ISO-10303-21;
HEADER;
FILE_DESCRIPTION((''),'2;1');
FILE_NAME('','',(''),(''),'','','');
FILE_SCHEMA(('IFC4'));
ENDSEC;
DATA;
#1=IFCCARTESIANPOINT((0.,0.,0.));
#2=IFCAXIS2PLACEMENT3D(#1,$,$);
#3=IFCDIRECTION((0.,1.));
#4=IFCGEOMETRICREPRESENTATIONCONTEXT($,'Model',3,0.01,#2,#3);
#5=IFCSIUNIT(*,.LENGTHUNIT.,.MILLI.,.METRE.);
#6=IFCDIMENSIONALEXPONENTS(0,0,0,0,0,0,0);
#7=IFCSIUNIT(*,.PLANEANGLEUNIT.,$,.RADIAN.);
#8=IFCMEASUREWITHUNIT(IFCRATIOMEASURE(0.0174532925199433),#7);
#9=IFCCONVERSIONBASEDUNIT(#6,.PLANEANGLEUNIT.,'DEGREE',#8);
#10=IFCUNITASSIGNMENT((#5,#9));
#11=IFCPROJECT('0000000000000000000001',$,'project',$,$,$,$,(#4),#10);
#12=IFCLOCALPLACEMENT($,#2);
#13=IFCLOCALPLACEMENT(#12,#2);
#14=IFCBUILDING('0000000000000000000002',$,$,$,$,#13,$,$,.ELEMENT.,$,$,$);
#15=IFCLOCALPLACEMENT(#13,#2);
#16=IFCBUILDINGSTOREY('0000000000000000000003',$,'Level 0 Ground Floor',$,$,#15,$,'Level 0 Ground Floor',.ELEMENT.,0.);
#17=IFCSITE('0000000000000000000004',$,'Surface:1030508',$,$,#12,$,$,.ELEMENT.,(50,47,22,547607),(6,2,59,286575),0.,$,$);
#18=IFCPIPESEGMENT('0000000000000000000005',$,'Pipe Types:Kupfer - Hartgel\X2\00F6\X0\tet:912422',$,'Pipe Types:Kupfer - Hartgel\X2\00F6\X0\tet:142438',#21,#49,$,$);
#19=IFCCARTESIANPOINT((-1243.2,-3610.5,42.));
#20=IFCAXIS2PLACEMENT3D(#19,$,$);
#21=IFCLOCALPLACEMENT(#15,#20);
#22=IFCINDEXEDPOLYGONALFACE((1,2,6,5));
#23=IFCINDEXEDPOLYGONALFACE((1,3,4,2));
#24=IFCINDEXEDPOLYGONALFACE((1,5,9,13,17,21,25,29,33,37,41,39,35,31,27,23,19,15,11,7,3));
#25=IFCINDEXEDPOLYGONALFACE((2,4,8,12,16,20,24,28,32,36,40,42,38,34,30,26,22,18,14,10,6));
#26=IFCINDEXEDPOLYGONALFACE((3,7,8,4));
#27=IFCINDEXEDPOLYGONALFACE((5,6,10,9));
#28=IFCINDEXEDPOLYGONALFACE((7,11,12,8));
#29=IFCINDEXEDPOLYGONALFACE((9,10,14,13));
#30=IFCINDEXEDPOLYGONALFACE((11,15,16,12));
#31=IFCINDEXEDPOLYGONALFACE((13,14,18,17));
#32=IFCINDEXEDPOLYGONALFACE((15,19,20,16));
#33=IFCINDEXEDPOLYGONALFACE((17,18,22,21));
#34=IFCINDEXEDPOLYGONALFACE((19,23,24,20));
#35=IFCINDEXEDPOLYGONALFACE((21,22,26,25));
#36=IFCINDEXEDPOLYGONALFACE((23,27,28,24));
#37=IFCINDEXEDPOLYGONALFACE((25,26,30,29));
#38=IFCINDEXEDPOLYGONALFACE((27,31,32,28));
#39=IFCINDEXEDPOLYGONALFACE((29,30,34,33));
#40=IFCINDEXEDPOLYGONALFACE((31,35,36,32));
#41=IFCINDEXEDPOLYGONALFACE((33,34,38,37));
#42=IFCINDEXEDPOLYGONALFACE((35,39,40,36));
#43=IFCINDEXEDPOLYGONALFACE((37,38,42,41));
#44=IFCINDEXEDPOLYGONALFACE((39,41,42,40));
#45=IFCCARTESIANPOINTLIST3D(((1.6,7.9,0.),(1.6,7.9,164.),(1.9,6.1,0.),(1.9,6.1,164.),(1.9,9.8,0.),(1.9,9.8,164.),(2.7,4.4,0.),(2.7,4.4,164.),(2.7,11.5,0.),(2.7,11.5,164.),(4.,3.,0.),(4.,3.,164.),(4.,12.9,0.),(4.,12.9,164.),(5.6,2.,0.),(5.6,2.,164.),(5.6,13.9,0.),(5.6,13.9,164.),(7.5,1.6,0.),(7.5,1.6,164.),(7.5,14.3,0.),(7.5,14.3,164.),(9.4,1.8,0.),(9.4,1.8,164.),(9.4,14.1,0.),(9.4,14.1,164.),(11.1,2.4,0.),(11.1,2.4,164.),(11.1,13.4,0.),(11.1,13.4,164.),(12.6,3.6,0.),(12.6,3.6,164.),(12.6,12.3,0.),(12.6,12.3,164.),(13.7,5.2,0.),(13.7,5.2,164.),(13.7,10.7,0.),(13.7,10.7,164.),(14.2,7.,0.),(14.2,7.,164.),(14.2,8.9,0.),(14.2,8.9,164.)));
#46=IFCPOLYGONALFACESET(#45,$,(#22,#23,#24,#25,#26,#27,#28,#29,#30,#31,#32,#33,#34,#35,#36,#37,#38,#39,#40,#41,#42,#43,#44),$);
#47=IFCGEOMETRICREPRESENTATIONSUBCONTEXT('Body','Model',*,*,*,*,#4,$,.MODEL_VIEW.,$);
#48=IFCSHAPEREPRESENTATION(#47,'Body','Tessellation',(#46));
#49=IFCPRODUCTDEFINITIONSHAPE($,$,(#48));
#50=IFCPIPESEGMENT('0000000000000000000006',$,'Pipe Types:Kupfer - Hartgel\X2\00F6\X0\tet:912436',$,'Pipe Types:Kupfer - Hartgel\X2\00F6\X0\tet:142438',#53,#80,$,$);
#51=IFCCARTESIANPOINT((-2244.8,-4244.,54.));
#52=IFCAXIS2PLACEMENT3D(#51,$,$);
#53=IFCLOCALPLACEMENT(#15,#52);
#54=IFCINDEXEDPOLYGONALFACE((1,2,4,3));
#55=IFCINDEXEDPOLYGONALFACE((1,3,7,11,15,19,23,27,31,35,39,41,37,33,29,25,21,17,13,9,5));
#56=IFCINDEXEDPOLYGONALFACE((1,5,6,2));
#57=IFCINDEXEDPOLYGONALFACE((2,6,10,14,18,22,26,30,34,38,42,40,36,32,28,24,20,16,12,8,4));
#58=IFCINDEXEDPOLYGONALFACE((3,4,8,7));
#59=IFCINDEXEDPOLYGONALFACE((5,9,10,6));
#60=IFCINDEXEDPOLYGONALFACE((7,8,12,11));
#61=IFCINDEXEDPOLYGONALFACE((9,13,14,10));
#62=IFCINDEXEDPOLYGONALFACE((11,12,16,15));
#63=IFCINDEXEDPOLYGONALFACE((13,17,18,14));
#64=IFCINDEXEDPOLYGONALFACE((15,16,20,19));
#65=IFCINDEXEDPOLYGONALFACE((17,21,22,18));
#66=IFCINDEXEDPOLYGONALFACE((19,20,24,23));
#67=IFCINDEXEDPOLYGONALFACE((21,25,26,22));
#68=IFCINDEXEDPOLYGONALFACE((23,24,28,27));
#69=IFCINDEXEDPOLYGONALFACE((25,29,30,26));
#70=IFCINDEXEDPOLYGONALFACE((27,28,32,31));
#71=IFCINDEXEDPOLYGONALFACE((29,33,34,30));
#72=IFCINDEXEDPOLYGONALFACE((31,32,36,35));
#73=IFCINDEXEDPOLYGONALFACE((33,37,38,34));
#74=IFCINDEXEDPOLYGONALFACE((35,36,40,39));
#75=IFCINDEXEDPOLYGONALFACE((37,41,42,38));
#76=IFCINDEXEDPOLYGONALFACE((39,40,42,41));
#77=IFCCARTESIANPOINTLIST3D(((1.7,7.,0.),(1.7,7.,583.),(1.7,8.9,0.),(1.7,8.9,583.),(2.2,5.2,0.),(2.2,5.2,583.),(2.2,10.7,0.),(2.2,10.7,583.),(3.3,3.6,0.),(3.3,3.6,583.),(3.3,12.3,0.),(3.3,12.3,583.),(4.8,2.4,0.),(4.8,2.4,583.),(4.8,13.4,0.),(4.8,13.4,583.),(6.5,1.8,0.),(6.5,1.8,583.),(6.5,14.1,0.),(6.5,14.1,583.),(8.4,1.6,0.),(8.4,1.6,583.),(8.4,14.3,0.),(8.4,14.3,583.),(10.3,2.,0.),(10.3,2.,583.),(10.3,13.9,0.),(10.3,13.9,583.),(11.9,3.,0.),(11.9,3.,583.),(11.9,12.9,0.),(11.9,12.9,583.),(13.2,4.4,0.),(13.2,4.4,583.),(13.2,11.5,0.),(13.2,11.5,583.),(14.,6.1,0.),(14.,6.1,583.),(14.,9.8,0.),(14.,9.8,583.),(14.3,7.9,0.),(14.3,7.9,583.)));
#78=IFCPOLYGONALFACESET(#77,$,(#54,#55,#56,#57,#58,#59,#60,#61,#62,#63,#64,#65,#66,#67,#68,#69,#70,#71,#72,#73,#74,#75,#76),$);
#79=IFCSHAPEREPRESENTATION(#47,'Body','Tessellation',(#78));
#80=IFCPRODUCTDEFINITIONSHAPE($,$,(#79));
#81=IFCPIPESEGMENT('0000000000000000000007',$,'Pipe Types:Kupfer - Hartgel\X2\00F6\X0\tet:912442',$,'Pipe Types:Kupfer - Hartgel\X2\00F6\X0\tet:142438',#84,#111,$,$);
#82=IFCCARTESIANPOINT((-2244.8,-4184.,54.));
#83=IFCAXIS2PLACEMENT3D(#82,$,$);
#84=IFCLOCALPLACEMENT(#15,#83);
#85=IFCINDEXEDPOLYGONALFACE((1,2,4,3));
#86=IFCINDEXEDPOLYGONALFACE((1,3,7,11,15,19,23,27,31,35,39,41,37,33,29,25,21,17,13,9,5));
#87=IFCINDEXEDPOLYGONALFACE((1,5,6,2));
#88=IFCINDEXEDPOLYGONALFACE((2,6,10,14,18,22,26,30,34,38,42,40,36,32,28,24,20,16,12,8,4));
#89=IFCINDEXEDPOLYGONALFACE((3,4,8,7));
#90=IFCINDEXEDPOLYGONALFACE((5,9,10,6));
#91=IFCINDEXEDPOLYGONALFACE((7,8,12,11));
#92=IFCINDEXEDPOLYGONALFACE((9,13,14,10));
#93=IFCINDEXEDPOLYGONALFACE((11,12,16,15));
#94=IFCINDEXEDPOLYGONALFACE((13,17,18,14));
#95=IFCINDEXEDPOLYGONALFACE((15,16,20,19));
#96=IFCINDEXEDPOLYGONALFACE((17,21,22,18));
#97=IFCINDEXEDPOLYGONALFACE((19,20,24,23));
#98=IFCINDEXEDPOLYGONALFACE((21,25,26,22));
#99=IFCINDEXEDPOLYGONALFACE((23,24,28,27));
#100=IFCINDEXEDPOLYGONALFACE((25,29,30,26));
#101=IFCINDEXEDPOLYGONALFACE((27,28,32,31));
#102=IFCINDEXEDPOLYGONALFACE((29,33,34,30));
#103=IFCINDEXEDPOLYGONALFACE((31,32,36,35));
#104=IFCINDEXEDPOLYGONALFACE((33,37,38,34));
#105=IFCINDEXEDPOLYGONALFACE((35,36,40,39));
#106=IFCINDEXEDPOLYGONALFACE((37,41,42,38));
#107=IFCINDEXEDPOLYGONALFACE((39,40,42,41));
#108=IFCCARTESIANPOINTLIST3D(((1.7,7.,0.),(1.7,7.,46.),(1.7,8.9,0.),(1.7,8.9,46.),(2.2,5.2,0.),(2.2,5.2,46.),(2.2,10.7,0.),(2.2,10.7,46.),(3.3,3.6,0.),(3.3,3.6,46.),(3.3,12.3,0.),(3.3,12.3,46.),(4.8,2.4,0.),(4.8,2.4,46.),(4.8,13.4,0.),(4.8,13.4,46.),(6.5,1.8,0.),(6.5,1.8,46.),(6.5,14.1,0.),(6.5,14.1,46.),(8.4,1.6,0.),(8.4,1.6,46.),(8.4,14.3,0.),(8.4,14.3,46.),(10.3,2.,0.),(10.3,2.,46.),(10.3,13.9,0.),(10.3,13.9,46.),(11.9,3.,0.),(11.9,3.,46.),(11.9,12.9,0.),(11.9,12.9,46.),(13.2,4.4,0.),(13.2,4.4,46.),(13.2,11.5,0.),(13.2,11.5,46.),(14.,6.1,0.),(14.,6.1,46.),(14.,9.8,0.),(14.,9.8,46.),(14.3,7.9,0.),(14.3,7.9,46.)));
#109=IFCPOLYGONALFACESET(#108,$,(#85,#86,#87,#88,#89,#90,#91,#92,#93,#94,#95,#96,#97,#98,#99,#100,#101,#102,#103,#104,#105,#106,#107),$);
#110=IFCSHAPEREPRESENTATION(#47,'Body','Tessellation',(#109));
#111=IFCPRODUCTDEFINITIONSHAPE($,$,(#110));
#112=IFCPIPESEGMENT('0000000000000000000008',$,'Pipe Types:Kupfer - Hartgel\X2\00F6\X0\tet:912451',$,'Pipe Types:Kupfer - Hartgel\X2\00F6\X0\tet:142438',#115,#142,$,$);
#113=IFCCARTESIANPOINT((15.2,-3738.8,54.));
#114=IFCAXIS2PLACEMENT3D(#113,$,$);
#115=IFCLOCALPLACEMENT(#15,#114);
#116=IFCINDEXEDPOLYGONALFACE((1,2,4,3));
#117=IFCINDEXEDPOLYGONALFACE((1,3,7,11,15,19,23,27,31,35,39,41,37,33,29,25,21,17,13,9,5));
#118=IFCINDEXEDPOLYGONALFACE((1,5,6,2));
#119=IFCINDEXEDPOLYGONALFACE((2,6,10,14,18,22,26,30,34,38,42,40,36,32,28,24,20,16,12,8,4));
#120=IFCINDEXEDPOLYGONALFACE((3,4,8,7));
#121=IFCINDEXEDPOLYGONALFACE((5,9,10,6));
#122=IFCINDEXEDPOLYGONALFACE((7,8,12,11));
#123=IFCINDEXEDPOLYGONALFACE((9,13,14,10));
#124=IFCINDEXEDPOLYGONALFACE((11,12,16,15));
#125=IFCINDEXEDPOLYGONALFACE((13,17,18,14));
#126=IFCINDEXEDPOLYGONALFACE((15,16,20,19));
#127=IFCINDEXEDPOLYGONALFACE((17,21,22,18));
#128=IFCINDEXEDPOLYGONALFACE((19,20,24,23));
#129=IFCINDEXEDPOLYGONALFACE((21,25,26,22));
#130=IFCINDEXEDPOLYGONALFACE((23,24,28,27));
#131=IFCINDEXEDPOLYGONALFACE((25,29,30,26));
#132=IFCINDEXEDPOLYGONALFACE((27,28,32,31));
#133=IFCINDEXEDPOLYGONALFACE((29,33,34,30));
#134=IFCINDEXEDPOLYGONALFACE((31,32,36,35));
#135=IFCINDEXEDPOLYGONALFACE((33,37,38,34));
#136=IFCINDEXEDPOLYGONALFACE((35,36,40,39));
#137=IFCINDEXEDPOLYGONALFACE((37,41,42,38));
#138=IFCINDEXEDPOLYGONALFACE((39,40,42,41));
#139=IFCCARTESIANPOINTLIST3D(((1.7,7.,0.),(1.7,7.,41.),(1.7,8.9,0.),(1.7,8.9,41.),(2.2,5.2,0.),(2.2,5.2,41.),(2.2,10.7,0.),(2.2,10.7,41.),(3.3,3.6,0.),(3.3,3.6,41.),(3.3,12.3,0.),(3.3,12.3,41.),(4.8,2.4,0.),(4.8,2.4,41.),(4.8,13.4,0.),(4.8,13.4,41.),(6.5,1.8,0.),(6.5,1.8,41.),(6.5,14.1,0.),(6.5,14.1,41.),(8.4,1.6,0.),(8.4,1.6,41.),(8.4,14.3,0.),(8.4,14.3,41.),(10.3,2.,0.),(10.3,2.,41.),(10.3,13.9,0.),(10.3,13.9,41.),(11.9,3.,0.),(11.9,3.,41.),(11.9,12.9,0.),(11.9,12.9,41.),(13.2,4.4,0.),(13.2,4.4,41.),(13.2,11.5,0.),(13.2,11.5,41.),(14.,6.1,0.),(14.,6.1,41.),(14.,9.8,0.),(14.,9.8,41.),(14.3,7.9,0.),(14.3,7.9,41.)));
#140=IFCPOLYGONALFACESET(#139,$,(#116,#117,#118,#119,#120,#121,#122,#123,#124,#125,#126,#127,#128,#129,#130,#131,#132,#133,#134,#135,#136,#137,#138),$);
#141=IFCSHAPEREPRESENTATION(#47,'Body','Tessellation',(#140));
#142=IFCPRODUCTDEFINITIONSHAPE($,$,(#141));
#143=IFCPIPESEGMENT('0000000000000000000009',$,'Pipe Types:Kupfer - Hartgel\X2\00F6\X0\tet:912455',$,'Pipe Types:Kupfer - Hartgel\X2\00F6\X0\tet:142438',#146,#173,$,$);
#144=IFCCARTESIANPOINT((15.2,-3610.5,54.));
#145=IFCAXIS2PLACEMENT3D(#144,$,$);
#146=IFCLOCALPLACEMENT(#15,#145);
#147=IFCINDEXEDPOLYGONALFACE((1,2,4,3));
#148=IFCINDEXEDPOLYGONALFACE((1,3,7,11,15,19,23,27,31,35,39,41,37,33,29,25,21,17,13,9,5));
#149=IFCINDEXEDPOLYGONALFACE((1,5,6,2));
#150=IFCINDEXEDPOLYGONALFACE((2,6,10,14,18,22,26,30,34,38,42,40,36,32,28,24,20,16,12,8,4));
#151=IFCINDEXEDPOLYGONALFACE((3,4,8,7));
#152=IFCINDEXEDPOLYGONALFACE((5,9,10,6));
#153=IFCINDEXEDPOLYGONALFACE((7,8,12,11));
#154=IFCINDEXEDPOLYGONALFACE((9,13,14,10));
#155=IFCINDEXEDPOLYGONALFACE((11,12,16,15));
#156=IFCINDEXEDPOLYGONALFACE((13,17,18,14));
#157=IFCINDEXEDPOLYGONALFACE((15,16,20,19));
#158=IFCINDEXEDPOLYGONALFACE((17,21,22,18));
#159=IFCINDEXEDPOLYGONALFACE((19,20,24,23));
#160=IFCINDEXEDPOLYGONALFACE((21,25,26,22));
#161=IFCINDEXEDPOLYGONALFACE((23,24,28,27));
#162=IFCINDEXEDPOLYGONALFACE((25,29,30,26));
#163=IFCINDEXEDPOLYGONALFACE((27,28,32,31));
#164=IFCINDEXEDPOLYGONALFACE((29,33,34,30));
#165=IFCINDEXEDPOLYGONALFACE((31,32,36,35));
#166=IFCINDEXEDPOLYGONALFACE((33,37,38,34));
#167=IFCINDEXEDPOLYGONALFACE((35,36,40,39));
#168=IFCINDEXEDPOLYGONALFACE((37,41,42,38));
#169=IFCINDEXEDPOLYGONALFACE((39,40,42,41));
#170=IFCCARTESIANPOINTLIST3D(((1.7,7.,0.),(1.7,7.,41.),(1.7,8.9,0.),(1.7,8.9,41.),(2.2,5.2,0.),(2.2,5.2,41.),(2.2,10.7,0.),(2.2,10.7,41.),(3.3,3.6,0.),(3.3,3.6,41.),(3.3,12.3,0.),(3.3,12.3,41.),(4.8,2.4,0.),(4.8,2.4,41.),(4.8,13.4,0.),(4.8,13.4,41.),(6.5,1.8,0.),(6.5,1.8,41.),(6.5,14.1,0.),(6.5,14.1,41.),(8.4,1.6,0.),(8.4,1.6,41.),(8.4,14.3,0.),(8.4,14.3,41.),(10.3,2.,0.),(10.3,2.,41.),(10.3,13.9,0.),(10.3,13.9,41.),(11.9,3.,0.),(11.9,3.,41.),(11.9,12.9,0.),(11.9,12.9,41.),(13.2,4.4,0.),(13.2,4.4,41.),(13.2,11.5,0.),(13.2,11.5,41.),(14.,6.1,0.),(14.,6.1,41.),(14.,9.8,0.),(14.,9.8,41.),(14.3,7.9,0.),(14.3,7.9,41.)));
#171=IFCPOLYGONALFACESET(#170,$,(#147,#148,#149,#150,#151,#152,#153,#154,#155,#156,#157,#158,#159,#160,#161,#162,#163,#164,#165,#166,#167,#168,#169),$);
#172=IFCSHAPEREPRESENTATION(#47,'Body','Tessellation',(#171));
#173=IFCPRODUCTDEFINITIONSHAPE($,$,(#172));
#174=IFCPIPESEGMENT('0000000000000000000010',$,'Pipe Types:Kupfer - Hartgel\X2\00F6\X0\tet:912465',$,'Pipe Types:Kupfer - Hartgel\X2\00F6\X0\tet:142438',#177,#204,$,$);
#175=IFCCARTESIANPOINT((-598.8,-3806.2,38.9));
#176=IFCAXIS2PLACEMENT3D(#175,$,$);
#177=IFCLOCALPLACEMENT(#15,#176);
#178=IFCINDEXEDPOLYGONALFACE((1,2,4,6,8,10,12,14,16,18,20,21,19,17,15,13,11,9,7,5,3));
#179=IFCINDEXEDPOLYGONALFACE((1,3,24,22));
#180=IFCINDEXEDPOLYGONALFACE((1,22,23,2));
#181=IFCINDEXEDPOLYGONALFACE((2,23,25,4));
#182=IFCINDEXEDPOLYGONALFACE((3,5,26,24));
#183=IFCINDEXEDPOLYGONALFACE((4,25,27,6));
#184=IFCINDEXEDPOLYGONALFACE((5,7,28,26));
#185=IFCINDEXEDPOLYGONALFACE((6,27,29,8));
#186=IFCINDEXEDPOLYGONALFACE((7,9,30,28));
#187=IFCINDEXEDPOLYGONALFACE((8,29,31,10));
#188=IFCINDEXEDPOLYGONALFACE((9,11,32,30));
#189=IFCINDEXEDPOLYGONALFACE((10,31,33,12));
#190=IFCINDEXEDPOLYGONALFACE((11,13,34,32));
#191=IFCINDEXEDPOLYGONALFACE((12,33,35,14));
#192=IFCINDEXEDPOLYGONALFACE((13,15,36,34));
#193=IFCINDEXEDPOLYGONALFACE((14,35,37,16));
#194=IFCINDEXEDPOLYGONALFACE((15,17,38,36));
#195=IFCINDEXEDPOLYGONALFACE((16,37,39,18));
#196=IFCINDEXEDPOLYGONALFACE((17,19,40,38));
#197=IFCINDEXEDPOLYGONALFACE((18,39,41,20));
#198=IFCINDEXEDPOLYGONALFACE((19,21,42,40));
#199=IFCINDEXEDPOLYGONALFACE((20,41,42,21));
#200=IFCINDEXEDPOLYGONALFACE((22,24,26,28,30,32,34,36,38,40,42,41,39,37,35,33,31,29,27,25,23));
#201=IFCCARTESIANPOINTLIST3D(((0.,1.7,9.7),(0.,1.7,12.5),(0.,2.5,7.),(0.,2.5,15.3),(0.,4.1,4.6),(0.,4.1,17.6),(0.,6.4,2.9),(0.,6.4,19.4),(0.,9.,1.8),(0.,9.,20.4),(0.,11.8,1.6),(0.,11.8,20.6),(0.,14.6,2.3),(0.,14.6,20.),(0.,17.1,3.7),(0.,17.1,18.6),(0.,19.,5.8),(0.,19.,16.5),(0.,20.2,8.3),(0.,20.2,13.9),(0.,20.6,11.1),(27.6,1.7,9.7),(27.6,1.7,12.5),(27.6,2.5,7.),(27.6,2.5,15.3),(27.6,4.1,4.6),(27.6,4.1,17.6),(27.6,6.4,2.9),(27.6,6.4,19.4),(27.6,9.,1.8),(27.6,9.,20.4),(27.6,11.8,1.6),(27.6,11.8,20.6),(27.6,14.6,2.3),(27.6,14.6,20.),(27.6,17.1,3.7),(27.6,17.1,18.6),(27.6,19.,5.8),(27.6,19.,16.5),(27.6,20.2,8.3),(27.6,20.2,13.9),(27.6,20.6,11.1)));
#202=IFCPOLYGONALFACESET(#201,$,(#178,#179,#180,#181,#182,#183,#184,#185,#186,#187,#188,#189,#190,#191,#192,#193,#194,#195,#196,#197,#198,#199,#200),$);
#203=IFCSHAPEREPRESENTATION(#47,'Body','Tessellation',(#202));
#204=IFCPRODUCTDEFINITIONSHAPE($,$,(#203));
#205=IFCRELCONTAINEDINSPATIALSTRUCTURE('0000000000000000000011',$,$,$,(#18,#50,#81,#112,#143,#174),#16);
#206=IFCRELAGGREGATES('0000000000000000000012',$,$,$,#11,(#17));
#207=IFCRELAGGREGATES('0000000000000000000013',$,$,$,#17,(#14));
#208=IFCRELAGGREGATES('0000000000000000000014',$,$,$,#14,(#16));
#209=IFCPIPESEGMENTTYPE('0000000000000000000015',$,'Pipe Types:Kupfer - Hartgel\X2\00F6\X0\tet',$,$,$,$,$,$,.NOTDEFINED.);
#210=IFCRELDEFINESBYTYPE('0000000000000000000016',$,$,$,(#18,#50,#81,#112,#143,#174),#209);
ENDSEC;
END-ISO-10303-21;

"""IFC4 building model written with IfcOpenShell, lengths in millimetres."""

from ifc_helpers import new_model, entity, si_unit, converted_unit, direction, frame, frame_2d, origin, origin_2d_with_axis, place, context, subcontext, project, spatial, circle, extrude, type_object, element, save


model = new_model("IFC4")

# Units and contexts
model_context = context("Model", 3, precision=0.01, world=origin(), true_north=direction((0.0, 1.0)))
body_context = subcontext(model_context, "Body", "Model", "MODEL_VIEW")
ifc_project = project(units=[si_unit("LENGTHUNIT", "METRE", prefix="MILLI"), converted_unit("PLANEANGLEUNIT", "DEGREE", entity("IfcRatioMeasure", 0.0174532925199433), si_unit("PLANEANGLEUNIT", "RADIAN"), dimensions=[0, 0, 0, 0, 0, 0, 0])], contexts=[model_context])

# Site, building, storey
site_placement = place(None, origin())
site = spatial("IfcSite", under=ifc_project, at=site_placement, Name="Surface:1030508", CompositionType="ELEMENT", RefLatitude=(50, 47, 22, 547607), RefLongitude=(6, 2, 59, 286575), RefElevation=0.0)
building_placement = place(site_placement, origin())
building = spatial("IfcBuilding", under=site, at=building_placement, CompositionType="ELEMENT")
storey_placement = place(building_placement, origin())
storey = spatial("IfcBuildingStorey", under=building, at=storey_placement, Name="Level 0 Ground Floor", LongName="Level 0 Ground Floor", CompositionType="ELEMENT", Elevation=0.0)

# Pipe segments
pipe_segment_type = type_object("IfcPipeSegmentType", Name="Pipe Types:Kupfer - Hartgelötet", PredefinedType="NOTDEFINED")
pipe_segment_1_placement = place(storey_placement, frame((-1243.2, -3610.5, 42.0)))
element("IfcPipeSegment", 1, at=pipe_segment_1_placement, inside=storey, type_object=pipe_segment_type, Name="Pipe Types:Kupfer - Hartgelötet:912422", ObjectType="Pipe Types:Kupfer - Hartgelötet:142438", context=body_context, shape_type="SweptSolid", body=[
    extrude(circle(Radius=6.3, at=frame_2d((0.0, 0.0), x_axis=(1.0, 0.0))), frame((7.9, 7.9, 0.0), z_axis=(0.0, 0.0, 1.0), x_axis=(-1.0, 0.0, 0.0)), (0.0, 0.0, 1.0), 164.0),
])
pipe_segment_2_placement = place(storey_placement, frame((-2244.8, -4244.0, 54.0)))
element("IfcPipeSegment", 2, at=pipe_segment_2_placement, inside=storey, type_object=pipe_segment_type, Name="Pipe Types:Kupfer - Hartgelötet:912436", ObjectType="Pipe Types:Kupfer - Hartgelötet:142438", context=body_context, shape_type="SweptSolid", body=[
    extrude(circle(Radius=6.3, at=frame_2d((0.0, 0.0), x_axis=(1.0, 0.0))), frame((7.9, 7.9, 0.0)), (0.0, 0.0, 1.0), 583.0),
])
pipe_segment_3_placement = place(storey_placement, frame((-2244.8, -4184.0, 54.0)))
element("IfcPipeSegment", 3, at=pipe_segment_3_placement, inside=storey, type_object=pipe_segment_type, Name="Pipe Types:Kupfer - Hartgelötet:912442", ObjectType="Pipe Types:Kupfer - Hartgelötet:142438", context=body_context, shape_type="SweptSolid", body=[
    extrude(circle(Radius=6.3, at=origin_2d_with_axis()), frame((7.9, 7.9, 0.0)), (0.0, 0.0, 1.0), 46.0),
])
pipe_segment_4_placement = place(storey_placement, frame((15.2, -3738.8, 54.0)))
element("IfcPipeSegment", 4, at=pipe_segment_4_placement, inside=storey, type_object=pipe_segment_type, Name="Pipe Types:Kupfer - Hartgelötet:912451", ObjectType="Pipe Types:Kupfer - Hartgelötet:142438", context=body_context, shape_type="SweptSolid", body=[
    extrude(circle(Radius=6.3, at=frame_2d((0.0, 0.0), x_axis=(1.0, 0.0))), frame((7.9, 7.9, 0.0)), (0.0, 0.0, 1.0), 41.0),
])
pipe_segment_5_placement = place(storey_placement, frame((15.2, -3610.5, 54.0)))
element("IfcPipeSegment", 5, at=pipe_segment_5_placement, inside=storey, type_object=pipe_segment_type, Name="Pipe Types:Kupfer - Hartgelötet:912455", ObjectType="Pipe Types:Kupfer - Hartgelötet:142438", context=body_context, shape_type="SweptSolid", body=[
    extrude(circle(Radius=6.3, at=frame_2d((0.0, 0.0), x_axis=(1.0, 0.0))), frame((7.9, 7.9, 0.0)), (0.0, 0.0, 1.0), 41.0),
])
pipe_segment_6_placement = place(storey_placement, frame((-598.8, -3806.2, 38.9)))
element("IfcPipeSegment", 6, at=pipe_segment_6_placement, inside=storey, type_object=pipe_segment_type, Name="Pipe Types:Kupfer - Hartgelötet:912465", ObjectType="Pipe Types:Kupfer - Hartgelötet:142438", context=body_context, shape_type="SweptSolid", body=[
    extrude(circle(Radius=9.5, at=frame_2d((0.0, 0.0), x_axis=(1.0, 0.0))), frame((0.0, 11.1, 11.1), z_axis=(1.0, 0.0, 0.0), x_axis=(0.0, 1.0, 0.0)), (0.0, 0.0, 1.0), 27.6),
])

save(model, "model.ifc")
